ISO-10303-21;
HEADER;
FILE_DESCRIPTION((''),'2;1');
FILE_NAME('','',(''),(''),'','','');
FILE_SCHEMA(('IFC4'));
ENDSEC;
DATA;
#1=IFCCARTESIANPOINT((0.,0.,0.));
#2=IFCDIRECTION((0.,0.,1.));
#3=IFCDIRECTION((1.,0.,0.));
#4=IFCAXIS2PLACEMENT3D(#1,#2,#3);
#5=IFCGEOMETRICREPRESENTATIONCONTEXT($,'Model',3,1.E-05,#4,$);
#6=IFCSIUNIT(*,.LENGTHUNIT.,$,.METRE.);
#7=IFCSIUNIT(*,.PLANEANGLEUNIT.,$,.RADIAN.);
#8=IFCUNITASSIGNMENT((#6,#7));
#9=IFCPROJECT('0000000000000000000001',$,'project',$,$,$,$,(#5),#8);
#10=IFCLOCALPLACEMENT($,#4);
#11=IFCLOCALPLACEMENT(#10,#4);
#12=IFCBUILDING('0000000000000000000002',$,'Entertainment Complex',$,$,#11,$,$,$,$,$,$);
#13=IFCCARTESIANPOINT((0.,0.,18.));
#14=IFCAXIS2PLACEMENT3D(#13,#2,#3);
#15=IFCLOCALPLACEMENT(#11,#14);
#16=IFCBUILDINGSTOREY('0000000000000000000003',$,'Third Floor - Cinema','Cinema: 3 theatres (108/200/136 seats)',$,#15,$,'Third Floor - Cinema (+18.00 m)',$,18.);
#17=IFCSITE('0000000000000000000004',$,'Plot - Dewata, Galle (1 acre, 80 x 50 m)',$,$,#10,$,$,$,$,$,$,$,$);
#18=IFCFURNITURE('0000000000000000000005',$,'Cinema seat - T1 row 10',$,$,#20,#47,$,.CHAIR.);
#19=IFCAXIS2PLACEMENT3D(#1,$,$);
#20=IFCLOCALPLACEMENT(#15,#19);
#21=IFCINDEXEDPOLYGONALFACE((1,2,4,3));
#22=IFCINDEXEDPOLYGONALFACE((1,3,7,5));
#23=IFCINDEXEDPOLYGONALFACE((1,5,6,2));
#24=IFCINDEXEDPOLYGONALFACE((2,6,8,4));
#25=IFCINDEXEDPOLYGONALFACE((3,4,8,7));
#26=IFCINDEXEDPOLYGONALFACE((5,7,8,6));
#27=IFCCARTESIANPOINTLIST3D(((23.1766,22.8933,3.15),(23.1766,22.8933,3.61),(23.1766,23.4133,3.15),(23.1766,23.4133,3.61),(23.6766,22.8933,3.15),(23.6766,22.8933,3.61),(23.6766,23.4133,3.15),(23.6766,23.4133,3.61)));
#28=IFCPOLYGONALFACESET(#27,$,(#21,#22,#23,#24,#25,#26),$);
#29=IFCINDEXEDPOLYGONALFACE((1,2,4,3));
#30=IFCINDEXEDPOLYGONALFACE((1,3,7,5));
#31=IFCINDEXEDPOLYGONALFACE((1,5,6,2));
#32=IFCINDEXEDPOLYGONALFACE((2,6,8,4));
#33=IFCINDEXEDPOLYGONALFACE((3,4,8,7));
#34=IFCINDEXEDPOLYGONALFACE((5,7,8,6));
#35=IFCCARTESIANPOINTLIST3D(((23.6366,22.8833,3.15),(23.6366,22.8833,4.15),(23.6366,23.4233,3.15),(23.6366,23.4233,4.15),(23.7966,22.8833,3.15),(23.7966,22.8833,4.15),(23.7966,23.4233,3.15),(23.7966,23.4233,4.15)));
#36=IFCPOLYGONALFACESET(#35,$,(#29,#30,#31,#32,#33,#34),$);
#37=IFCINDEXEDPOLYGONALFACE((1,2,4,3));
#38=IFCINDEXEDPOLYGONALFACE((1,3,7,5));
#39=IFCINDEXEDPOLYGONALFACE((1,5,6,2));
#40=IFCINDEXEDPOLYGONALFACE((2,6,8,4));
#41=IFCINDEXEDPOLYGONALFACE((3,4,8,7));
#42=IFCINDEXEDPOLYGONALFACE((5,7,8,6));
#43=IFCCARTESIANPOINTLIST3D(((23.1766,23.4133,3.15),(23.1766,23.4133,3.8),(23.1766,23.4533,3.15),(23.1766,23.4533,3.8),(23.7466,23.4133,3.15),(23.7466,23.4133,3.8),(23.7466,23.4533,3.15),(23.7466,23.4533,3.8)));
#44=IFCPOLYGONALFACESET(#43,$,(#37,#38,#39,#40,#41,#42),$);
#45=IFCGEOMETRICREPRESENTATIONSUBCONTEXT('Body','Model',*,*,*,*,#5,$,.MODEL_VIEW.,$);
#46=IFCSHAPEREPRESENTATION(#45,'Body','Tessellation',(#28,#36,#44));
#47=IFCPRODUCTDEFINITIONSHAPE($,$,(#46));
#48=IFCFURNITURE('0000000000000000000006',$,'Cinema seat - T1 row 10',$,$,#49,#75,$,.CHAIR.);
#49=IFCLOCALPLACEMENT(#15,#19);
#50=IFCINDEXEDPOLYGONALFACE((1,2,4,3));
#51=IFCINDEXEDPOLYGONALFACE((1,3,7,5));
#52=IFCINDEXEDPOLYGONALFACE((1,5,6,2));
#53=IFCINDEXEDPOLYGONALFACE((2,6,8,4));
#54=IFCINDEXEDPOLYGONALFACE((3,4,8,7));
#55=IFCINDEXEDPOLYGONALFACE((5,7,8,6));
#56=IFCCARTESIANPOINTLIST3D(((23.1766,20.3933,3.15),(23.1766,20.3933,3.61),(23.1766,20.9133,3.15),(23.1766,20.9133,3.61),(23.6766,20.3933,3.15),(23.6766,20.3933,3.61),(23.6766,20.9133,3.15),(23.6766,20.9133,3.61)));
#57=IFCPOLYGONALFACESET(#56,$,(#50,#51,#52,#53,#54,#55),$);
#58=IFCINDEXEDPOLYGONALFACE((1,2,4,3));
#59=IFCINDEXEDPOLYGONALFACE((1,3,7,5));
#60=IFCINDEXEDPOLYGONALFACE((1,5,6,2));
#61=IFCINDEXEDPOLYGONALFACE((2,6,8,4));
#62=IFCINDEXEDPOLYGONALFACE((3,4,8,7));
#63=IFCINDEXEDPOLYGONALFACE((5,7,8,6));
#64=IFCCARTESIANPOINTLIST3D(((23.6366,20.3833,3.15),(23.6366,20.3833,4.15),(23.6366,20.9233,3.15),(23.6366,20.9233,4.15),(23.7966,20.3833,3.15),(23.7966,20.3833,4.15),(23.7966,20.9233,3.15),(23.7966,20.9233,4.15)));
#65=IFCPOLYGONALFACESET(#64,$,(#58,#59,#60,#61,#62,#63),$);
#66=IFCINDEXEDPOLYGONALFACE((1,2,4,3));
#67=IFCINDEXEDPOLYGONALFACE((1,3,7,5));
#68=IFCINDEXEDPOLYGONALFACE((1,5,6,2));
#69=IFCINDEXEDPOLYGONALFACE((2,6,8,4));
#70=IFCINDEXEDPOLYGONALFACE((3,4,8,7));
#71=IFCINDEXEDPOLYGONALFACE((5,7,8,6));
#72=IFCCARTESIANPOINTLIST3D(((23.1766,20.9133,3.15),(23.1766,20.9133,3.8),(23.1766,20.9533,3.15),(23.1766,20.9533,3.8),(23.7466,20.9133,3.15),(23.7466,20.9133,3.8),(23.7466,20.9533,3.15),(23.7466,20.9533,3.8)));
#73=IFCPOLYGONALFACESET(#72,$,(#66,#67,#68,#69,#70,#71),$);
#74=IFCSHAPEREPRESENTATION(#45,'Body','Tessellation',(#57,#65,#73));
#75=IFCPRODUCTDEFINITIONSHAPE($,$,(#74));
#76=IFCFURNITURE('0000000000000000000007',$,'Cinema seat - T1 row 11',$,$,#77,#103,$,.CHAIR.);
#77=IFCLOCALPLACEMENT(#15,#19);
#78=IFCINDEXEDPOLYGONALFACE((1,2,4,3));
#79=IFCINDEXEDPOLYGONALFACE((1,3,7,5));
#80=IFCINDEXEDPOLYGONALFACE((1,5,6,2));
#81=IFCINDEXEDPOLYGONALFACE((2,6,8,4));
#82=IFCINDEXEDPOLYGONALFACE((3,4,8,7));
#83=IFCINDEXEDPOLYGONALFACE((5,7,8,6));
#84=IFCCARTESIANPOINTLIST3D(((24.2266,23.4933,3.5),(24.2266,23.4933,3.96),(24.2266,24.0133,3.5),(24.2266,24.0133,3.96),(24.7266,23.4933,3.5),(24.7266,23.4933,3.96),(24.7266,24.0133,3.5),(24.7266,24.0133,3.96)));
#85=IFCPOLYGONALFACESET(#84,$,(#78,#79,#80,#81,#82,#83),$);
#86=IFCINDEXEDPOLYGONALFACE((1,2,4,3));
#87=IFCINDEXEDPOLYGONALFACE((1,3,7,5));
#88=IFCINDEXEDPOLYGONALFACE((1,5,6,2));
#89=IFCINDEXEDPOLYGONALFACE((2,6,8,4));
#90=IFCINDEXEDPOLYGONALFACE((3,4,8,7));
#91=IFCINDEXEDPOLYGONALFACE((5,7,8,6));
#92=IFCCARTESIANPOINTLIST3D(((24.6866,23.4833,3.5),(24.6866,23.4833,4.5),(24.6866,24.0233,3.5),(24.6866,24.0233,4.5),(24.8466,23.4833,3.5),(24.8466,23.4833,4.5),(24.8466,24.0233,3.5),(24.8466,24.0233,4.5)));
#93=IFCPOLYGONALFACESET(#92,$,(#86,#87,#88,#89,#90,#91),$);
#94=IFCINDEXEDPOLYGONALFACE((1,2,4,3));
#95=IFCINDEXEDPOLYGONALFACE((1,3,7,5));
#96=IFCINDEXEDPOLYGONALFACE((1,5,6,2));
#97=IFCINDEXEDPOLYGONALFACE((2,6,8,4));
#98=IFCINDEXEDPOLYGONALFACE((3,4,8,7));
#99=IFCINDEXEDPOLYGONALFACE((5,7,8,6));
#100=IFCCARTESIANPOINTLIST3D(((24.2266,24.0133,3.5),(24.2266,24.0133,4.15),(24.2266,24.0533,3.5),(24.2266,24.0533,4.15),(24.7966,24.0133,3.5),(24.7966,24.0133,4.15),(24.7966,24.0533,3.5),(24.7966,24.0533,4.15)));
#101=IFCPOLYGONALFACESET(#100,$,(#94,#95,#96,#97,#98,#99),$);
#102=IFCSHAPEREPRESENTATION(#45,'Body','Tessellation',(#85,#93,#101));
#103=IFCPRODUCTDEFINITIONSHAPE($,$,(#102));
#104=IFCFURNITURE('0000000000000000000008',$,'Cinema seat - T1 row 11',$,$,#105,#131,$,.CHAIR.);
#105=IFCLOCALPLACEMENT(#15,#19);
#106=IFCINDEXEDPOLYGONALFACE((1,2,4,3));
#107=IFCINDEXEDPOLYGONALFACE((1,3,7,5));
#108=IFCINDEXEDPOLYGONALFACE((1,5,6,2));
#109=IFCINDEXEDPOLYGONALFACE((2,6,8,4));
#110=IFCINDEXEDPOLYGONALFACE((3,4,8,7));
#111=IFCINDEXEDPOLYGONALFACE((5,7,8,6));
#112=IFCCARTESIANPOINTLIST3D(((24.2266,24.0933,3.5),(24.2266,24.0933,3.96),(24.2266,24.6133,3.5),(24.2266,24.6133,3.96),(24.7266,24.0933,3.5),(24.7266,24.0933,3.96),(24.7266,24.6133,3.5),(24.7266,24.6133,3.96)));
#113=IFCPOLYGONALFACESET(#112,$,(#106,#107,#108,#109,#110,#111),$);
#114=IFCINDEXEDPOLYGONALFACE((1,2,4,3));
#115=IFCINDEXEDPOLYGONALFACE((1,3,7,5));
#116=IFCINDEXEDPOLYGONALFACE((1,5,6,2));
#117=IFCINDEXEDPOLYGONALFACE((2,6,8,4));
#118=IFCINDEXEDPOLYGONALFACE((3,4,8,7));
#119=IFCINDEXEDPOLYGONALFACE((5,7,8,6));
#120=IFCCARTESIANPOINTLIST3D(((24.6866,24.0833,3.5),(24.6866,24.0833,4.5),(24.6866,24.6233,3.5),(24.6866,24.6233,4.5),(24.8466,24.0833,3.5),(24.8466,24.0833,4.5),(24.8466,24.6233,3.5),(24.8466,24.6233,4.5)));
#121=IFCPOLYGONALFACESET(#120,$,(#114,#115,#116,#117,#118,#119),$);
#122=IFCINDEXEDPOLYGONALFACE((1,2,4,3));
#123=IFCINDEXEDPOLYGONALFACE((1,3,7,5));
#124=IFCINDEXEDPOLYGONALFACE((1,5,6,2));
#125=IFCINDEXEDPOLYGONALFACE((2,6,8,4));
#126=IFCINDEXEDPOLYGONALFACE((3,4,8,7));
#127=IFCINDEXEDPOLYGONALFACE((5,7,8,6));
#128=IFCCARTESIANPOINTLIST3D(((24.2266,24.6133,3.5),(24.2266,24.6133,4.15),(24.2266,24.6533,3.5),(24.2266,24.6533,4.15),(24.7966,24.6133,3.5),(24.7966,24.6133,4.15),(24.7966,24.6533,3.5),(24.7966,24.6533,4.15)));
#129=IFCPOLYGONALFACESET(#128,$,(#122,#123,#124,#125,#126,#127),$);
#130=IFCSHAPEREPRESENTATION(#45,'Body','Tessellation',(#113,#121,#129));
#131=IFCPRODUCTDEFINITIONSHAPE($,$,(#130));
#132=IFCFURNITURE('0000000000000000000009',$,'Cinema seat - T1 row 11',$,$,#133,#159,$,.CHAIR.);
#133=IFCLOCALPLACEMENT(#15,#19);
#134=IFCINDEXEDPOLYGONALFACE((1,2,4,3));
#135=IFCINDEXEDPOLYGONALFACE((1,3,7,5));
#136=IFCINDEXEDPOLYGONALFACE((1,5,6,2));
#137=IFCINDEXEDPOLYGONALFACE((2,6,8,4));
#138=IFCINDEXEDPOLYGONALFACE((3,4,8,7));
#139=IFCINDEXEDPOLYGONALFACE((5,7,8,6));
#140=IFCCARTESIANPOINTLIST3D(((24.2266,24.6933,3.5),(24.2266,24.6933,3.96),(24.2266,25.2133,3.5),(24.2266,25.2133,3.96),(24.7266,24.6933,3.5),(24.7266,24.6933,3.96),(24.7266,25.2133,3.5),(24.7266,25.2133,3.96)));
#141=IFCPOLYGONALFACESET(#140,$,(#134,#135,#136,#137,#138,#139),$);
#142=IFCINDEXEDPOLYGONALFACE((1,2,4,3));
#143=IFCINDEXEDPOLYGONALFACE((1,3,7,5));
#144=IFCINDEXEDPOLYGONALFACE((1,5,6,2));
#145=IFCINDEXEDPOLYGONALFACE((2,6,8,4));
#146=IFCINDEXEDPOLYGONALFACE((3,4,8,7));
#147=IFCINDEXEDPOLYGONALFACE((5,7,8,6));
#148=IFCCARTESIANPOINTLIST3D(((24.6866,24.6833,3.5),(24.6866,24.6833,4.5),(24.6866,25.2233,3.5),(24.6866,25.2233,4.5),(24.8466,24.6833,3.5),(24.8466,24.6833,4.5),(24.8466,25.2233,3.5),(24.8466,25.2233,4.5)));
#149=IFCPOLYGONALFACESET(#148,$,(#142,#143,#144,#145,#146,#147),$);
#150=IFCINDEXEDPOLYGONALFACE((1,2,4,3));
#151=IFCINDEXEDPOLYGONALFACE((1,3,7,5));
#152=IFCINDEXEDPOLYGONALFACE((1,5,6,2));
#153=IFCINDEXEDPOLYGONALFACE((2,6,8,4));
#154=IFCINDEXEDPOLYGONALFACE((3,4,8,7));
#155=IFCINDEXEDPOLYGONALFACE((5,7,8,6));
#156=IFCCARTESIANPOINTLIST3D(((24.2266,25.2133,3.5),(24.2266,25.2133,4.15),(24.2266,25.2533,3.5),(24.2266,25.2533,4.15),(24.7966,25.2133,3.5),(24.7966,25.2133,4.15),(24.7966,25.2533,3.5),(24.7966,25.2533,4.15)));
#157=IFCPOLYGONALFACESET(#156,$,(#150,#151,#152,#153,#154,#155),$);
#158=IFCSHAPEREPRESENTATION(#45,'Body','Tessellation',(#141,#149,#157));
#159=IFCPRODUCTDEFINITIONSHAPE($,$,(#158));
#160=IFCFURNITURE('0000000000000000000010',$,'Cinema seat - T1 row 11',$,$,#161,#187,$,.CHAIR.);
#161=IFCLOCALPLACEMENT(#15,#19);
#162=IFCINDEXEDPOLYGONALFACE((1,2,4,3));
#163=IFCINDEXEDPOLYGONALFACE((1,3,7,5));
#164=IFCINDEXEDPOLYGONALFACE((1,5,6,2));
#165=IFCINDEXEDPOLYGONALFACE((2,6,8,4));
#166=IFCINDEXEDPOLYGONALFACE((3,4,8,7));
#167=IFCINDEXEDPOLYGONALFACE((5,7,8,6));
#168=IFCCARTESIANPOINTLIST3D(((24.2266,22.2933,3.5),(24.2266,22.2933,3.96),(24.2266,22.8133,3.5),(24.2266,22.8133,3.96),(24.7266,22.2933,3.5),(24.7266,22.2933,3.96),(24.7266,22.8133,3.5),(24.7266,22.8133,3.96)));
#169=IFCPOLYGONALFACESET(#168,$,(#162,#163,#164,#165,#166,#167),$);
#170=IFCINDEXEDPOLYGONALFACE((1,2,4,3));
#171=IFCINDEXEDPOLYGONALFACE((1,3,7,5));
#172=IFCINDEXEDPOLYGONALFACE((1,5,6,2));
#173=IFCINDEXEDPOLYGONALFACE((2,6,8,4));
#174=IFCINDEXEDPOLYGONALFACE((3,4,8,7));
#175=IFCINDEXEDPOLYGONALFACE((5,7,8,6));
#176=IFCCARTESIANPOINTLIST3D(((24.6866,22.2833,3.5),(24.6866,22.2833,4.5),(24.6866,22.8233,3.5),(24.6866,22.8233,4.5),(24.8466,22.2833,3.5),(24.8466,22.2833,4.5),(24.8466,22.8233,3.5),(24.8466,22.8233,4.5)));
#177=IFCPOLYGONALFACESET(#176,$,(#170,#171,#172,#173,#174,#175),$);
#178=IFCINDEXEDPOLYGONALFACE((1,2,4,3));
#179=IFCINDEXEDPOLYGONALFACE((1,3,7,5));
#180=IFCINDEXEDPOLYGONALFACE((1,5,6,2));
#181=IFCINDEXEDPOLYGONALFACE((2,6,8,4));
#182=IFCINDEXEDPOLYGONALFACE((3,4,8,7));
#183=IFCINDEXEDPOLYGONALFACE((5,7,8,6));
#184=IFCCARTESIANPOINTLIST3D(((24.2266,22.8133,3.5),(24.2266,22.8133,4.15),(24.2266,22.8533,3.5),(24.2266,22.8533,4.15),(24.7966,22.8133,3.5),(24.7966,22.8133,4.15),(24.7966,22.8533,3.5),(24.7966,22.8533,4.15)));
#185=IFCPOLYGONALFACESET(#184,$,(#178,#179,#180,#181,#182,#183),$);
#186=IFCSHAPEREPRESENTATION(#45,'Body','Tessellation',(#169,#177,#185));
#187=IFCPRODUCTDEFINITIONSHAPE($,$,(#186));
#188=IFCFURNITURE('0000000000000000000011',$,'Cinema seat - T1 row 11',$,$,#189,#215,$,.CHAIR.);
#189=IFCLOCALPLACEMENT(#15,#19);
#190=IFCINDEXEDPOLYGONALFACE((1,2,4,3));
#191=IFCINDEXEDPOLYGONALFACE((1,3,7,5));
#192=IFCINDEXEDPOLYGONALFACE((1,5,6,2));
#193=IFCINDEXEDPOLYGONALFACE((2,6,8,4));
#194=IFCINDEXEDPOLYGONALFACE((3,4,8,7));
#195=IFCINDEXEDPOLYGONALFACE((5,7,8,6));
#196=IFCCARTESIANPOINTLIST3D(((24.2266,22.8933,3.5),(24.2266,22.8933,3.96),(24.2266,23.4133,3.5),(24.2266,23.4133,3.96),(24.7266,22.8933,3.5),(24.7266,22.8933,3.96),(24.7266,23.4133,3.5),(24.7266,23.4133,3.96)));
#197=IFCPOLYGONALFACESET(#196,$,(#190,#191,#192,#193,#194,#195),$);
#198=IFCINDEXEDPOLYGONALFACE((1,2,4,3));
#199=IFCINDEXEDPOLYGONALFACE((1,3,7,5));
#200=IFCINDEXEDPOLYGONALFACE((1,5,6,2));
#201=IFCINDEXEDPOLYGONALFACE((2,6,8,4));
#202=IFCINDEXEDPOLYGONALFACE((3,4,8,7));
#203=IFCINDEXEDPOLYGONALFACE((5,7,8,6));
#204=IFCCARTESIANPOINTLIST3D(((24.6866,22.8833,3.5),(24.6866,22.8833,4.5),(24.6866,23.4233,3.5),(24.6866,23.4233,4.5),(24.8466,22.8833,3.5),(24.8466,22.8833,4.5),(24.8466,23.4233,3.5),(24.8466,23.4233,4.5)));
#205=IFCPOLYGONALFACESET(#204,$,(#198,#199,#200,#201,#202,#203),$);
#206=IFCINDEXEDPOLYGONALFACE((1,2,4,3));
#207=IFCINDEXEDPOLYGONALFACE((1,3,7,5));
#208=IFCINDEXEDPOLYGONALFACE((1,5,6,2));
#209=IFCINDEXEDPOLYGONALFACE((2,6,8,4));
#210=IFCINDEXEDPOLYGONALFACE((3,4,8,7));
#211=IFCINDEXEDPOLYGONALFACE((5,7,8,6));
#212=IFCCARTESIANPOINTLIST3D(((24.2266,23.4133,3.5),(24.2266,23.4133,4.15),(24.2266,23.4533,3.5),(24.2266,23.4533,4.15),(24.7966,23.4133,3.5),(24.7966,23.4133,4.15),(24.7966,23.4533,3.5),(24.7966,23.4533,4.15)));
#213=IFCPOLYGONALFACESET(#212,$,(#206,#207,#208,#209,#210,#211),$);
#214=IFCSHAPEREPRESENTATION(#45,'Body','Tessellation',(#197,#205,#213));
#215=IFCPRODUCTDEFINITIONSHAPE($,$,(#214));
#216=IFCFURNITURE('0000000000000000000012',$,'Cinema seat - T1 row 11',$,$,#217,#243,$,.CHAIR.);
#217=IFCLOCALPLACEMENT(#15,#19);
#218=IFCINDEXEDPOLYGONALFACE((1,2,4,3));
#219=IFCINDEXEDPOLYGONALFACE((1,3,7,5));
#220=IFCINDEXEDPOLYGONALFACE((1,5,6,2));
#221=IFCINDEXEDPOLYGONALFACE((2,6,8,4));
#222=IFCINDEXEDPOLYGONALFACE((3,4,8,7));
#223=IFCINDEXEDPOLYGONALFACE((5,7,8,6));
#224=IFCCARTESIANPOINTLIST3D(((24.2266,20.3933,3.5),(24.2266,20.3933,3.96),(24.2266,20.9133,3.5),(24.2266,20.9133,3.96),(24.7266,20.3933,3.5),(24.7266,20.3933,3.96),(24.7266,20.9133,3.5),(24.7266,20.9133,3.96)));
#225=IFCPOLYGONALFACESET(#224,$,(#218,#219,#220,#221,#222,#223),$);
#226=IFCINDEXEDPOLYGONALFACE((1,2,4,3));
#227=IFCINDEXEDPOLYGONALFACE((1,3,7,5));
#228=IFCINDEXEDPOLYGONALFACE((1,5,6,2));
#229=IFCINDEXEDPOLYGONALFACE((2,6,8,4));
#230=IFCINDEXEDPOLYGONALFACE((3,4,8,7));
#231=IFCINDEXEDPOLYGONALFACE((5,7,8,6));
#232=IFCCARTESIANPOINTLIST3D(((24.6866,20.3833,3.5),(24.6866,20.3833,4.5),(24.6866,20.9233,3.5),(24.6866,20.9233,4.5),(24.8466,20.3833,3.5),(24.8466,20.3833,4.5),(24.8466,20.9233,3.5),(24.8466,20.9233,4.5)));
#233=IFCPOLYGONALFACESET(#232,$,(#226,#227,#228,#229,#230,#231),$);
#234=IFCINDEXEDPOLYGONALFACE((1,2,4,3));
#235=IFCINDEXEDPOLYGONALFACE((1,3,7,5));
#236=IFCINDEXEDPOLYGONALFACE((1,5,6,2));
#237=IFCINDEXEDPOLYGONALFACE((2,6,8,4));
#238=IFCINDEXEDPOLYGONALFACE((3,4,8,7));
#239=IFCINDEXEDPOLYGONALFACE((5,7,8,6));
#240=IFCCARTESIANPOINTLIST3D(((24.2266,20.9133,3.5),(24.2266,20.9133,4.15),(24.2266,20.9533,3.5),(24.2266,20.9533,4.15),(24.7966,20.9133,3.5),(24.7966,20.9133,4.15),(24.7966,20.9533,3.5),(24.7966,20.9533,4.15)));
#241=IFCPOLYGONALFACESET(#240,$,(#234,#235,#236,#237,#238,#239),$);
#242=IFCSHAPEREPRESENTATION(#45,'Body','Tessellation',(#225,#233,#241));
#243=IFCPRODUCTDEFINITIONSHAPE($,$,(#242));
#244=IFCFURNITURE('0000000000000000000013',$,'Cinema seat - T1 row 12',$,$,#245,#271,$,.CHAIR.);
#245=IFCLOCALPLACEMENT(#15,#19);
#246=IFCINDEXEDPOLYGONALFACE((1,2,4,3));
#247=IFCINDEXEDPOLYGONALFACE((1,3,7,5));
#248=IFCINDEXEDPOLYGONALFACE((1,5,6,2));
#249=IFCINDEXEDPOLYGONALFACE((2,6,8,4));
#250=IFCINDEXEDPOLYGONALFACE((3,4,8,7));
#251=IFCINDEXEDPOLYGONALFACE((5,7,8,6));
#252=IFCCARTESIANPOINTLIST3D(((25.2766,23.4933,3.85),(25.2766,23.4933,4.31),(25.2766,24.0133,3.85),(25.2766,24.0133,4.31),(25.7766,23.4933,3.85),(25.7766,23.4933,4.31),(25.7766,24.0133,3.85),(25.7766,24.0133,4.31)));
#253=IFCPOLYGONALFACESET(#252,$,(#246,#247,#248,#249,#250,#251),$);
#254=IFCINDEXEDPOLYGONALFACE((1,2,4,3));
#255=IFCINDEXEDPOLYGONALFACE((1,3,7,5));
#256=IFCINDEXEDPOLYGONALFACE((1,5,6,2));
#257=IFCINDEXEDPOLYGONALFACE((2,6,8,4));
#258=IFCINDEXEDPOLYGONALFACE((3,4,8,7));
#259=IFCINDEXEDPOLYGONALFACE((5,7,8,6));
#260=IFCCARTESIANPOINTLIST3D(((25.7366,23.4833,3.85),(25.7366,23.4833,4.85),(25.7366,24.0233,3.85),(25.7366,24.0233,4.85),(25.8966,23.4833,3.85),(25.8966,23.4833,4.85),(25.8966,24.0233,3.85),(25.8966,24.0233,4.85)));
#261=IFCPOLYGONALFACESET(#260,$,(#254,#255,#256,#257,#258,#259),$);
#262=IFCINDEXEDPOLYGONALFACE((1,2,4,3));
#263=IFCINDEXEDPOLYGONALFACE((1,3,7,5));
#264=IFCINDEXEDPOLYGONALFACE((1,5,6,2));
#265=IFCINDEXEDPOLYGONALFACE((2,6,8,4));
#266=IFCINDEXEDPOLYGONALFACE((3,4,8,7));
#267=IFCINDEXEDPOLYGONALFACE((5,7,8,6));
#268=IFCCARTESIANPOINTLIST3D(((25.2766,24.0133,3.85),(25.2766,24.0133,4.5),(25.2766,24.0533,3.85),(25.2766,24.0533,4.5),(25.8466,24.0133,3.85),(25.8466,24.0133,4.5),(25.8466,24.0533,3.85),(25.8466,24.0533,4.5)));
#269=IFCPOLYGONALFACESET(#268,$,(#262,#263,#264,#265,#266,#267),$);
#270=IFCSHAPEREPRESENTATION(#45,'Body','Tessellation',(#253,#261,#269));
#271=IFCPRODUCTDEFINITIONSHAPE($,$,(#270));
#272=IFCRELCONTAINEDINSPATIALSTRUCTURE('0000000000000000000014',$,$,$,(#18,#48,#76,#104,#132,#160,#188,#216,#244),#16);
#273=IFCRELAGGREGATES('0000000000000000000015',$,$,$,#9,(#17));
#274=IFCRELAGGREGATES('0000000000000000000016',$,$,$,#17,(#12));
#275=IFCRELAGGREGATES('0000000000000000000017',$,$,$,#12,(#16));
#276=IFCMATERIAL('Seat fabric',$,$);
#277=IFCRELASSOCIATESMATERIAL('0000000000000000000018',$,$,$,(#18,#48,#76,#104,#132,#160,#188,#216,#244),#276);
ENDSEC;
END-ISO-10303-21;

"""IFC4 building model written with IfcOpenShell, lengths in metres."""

from ifc_helpers import new_model, si_unit, frame, origin_with_axes, place, context, subcontext, project, spatial, polyline, outline, extrude, material, element, save


model = new_model("IFC4")

# Units and contexts
model_context = context("Model", 3, precision=1e-05, world=origin_with_axes())
body_context = subcontext(model_context, "Body", "Model", "MODEL_VIEW")
ifc_project = project(units=[si_unit("LENGTHUNIT", "METRE"), si_unit("PLANEANGLEUNIT", "RADIAN")], contexts=[model_context])

# Site, building, storey
site_placement = place(None, origin_with_axes())
site = spatial("IfcSite", under=ifc_project, at=site_placement, Name="Plot - Dewata, Galle (1 acre, 80 x 50 m)")
building_placement = place(site_placement, origin_with_axes())
building = spatial("IfcBuilding", under=site, at=building_placement, Name="Entertainment Complex")
storey_placement = place(building_placement, frame((0.0, 0.0, 18.0), z_axis=(0.0, 0.0, 1.0), x_axis=(1.0, 0.0, 0.0)))
storey = spatial("IfcBuildingStorey", under=building, at=storey_placement, Name="Third Floor - Cinema", Description="Cinema: 3 theatres (108/200/136 seats)", LongName="Third Floor - Cinema (+18.00 m)", Elevation=18.0)

# Furniture
ifc_material_1 = material(Name="Seat fabric")
for number, where, z_axis, x_axis, name in (
    (1, (23.7966, 23.1533, 3.15), (0.0, 0.0, 1.0), (1.0, 0.0, 0.0), "Cinema seat - T1 row 10"),
    (2, (23.7966, 20.6533, 3.15), (0.0, 0.0, 1.0), (1.0, 0.0, 0.0), "Cinema seat - T1 row 10"),
    (3, (24.8466, 23.7533, 3.5), (0.0, 0.0, 1.0), (1.0, 0.0, 0.0), "Cinema seat - T1 row 11"),
    (4, (24.8466, 24.3533, 3.5), (0.0, 0.0, 1.0), (1.0, 0.0, 0.0), "Cinema seat - T1 row 11"),
    (5, (24.8466, 24.9533, 3.5), (0.0, 0.0, 1.0), (1.0, 0.0, 0.0), "Cinema seat - T1 row 11"),
    (6, (24.8466, 22.5533, 3.5), (0.0, 0.0, 1.0), (1.0, 0.0, 0.0), "Cinema seat - T1 row 11"),
    (7, (24.8466, 23.1533, 3.5), (0.0, 0.0, 1.0), (1.0, 0.0, 0.0), "Cinema seat - T1 row 11"),
    (8, (24.8466, 20.6533, 3.5), (0.0, 0.0, 1.0), (1.0, 0.0, 0.0), "Cinema seat - T1 row 11"),
    (9, (25.8966, 23.7533, 3.85), (0.0, 0.0, 1.0), (1.0, 0.0, 0.0), "Cinema seat - T1 row 12"),
):
    element("IfcFurniture", number, at=place(storey_placement, frame(where, z_axis=z_axis, x_axis=x_axis)), inside=storey, material=ifc_material_1, Name=name, PredefinedType="CHAIR", context=body_context, shape_type="SweptSolid", body=[
        extrude(outline(polyline([(-0.62, -0.26), (-0.12, -0.26), (-0.12, 0.26), (-0.62, 0.26), (-0.62, -0.26)])), origin_with_axes(), (0.0, 0.0, 1.0), 0.46),
        extrude(outline(polyline([(-0.16, -0.27), (0.0, -0.27), (0.0, 0.27), (-0.16, 0.27), (-0.16, -0.27)])), origin_with_axes(), (0.0, 0.0, 1.0), 1.0),
        extrude(outline(polyline([(-0.62, 0.26), (-0.05, 0.26), (-0.05, 0.3), (-0.62, 0.3), (-0.62, 0.26)])), origin_with_axes(), (0.0, 0.0, 1.0), 0.65),
    ])

save(model, "model.ifc")
